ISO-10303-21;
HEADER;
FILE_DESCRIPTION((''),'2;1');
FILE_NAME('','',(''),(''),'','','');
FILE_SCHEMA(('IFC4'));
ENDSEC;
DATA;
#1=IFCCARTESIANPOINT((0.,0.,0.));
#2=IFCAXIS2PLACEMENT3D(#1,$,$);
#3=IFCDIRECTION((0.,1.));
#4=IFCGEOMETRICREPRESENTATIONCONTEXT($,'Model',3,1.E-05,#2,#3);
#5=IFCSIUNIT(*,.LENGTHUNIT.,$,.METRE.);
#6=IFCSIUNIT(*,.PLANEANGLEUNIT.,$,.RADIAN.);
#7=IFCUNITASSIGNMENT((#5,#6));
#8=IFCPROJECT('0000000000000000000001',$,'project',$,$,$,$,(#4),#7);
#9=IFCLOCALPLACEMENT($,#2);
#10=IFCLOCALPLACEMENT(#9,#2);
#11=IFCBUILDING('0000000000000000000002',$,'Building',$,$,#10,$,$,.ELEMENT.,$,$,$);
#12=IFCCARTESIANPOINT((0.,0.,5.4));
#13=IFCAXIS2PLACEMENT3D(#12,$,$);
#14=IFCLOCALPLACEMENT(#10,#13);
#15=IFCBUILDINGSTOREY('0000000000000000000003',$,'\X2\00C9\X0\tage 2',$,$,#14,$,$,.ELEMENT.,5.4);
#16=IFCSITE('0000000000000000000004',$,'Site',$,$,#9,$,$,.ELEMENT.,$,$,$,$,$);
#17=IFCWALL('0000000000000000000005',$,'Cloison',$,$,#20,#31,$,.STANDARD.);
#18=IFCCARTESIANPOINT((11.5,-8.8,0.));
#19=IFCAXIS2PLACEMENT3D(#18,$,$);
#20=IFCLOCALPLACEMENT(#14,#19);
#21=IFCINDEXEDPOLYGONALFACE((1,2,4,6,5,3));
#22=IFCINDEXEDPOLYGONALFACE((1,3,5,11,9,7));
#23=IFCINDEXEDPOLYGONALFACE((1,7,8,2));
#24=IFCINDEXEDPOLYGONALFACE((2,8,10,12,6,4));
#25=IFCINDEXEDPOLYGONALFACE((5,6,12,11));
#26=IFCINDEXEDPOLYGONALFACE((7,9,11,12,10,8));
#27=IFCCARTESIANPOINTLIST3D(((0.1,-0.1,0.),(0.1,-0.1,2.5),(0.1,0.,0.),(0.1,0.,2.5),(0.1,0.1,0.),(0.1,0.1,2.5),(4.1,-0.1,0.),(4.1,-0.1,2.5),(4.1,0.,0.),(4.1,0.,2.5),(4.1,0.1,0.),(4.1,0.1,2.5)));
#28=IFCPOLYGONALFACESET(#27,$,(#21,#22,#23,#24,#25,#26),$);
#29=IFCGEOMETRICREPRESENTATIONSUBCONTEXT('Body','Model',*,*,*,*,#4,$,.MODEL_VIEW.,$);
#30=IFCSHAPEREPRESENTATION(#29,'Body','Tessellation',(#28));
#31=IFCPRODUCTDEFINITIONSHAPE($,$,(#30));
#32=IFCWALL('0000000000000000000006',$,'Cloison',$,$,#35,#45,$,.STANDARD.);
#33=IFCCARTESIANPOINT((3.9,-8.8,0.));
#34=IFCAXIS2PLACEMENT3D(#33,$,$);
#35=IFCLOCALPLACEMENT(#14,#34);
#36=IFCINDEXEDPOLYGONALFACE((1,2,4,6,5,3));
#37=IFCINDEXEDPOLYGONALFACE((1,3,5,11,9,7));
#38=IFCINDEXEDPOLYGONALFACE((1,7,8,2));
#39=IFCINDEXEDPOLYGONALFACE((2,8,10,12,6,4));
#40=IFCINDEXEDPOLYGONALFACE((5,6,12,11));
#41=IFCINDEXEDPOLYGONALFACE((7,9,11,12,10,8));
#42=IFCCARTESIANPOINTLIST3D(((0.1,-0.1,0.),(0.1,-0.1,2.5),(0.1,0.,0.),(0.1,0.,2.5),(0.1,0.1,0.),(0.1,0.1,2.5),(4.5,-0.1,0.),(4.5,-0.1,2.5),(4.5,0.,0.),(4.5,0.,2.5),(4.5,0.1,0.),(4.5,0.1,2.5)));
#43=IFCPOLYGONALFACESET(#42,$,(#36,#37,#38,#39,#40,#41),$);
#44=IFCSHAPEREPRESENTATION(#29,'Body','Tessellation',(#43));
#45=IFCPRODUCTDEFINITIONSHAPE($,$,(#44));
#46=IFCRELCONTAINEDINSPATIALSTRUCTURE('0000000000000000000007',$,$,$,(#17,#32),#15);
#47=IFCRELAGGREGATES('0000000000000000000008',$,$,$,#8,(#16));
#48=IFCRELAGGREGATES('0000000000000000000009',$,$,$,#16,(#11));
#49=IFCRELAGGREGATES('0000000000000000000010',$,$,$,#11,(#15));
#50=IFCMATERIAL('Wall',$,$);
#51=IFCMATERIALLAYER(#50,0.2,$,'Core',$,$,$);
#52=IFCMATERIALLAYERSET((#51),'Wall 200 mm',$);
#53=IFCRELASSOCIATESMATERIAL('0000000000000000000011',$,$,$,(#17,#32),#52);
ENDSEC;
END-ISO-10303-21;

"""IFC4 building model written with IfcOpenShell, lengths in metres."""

from ifc_helpers import new_model, si_unit, direction, frame, origin, place, context, subcontext, project, spatial, polyline, outline, extrude, material, layer, layer_set, layer_usage, element, save


model = new_model("IFC4")

# Units and contexts
model_context = context("Model", 3, precision=1e-05, world=origin(), true_north=direction((0.0, 1.0)))
body_context = subcontext(model_context, "Body", "Model", "MODEL_VIEW")
ifc_project = project(units=[si_unit("LENGTHUNIT", "METRE"), si_unit("PLANEANGLEUNIT", "RADIAN")], contexts=[model_context])

# Site, building, storey
site_placement = place(None, origin())
site = spatial("IfcSite", under=ifc_project, at=site_placement, Name="Site", CompositionType="ELEMENT")
building_placement = place(site_placement, origin())
building = spatial("IfcBuilding", under=site, at=building_placement, Name="Building", CompositionType="ELEMENT")
storey_placement = place(building_placement, frame((0.0, 0.0, 5.4)))
storey = spatial("IfcBuildingStorey", under=building, at=storey_placement, Name="Étage 2", CompositionType="ELEMENT", Elevation=5.4)

# Shared definitions
ifc_material = material(Name="Wall")
ifc_layer = layer(ifc_material, 0.2, Name="Core")
ifc_layer_set = layer_set([ifc_layer], Name="Wall 200 mm")
ifc_layer_usage = layer_usage(ifc_layer_set, "AXIS2", "POSITIVE", -0.1)

# Walls
wall_1_placement = place(storey_placement, frame((11.5, -8.8, 0.0)))
element("IfcWall", 1, at=wall_1_placement, inside=storey, material=ifc_layer_usage, Name="Cloison", PredefinedType="STANDARD", context=body_context, shape_type="SweptSolid", body=[
    extrude(outline(polyline([(0.1, 0.0), (0.1, -0.1), (4.1, -0.1), (4.1, 0.0), (4.1, 0.1), (0.1, 0.1), (0.1, 0.0)])), origin(), (0.0, 0.0, 1.0), 2.5),
])
wall_2_placement = place(storey_placement, frame((3.9, -8.8, 0.0)))
element("IfcWall", 2, at=wall_2_placement, inside=storey, material=ifc_layer_usage, Name="Cloison", PredefinedType="STANDARD", context=body_context, shape_type="SweptSolid", body=[
    extrude(outline(polyline([(0.1, 0.0), (0.1, -0.1), (4.5, -0.1), (4.5, 0.0), (4.5, 0.1), (0.1, 0.1), (0.1, 0.0)])), origin(), (0.0, 0.0, 1.0), 2.5),
])

save(model, "model.ifc")
